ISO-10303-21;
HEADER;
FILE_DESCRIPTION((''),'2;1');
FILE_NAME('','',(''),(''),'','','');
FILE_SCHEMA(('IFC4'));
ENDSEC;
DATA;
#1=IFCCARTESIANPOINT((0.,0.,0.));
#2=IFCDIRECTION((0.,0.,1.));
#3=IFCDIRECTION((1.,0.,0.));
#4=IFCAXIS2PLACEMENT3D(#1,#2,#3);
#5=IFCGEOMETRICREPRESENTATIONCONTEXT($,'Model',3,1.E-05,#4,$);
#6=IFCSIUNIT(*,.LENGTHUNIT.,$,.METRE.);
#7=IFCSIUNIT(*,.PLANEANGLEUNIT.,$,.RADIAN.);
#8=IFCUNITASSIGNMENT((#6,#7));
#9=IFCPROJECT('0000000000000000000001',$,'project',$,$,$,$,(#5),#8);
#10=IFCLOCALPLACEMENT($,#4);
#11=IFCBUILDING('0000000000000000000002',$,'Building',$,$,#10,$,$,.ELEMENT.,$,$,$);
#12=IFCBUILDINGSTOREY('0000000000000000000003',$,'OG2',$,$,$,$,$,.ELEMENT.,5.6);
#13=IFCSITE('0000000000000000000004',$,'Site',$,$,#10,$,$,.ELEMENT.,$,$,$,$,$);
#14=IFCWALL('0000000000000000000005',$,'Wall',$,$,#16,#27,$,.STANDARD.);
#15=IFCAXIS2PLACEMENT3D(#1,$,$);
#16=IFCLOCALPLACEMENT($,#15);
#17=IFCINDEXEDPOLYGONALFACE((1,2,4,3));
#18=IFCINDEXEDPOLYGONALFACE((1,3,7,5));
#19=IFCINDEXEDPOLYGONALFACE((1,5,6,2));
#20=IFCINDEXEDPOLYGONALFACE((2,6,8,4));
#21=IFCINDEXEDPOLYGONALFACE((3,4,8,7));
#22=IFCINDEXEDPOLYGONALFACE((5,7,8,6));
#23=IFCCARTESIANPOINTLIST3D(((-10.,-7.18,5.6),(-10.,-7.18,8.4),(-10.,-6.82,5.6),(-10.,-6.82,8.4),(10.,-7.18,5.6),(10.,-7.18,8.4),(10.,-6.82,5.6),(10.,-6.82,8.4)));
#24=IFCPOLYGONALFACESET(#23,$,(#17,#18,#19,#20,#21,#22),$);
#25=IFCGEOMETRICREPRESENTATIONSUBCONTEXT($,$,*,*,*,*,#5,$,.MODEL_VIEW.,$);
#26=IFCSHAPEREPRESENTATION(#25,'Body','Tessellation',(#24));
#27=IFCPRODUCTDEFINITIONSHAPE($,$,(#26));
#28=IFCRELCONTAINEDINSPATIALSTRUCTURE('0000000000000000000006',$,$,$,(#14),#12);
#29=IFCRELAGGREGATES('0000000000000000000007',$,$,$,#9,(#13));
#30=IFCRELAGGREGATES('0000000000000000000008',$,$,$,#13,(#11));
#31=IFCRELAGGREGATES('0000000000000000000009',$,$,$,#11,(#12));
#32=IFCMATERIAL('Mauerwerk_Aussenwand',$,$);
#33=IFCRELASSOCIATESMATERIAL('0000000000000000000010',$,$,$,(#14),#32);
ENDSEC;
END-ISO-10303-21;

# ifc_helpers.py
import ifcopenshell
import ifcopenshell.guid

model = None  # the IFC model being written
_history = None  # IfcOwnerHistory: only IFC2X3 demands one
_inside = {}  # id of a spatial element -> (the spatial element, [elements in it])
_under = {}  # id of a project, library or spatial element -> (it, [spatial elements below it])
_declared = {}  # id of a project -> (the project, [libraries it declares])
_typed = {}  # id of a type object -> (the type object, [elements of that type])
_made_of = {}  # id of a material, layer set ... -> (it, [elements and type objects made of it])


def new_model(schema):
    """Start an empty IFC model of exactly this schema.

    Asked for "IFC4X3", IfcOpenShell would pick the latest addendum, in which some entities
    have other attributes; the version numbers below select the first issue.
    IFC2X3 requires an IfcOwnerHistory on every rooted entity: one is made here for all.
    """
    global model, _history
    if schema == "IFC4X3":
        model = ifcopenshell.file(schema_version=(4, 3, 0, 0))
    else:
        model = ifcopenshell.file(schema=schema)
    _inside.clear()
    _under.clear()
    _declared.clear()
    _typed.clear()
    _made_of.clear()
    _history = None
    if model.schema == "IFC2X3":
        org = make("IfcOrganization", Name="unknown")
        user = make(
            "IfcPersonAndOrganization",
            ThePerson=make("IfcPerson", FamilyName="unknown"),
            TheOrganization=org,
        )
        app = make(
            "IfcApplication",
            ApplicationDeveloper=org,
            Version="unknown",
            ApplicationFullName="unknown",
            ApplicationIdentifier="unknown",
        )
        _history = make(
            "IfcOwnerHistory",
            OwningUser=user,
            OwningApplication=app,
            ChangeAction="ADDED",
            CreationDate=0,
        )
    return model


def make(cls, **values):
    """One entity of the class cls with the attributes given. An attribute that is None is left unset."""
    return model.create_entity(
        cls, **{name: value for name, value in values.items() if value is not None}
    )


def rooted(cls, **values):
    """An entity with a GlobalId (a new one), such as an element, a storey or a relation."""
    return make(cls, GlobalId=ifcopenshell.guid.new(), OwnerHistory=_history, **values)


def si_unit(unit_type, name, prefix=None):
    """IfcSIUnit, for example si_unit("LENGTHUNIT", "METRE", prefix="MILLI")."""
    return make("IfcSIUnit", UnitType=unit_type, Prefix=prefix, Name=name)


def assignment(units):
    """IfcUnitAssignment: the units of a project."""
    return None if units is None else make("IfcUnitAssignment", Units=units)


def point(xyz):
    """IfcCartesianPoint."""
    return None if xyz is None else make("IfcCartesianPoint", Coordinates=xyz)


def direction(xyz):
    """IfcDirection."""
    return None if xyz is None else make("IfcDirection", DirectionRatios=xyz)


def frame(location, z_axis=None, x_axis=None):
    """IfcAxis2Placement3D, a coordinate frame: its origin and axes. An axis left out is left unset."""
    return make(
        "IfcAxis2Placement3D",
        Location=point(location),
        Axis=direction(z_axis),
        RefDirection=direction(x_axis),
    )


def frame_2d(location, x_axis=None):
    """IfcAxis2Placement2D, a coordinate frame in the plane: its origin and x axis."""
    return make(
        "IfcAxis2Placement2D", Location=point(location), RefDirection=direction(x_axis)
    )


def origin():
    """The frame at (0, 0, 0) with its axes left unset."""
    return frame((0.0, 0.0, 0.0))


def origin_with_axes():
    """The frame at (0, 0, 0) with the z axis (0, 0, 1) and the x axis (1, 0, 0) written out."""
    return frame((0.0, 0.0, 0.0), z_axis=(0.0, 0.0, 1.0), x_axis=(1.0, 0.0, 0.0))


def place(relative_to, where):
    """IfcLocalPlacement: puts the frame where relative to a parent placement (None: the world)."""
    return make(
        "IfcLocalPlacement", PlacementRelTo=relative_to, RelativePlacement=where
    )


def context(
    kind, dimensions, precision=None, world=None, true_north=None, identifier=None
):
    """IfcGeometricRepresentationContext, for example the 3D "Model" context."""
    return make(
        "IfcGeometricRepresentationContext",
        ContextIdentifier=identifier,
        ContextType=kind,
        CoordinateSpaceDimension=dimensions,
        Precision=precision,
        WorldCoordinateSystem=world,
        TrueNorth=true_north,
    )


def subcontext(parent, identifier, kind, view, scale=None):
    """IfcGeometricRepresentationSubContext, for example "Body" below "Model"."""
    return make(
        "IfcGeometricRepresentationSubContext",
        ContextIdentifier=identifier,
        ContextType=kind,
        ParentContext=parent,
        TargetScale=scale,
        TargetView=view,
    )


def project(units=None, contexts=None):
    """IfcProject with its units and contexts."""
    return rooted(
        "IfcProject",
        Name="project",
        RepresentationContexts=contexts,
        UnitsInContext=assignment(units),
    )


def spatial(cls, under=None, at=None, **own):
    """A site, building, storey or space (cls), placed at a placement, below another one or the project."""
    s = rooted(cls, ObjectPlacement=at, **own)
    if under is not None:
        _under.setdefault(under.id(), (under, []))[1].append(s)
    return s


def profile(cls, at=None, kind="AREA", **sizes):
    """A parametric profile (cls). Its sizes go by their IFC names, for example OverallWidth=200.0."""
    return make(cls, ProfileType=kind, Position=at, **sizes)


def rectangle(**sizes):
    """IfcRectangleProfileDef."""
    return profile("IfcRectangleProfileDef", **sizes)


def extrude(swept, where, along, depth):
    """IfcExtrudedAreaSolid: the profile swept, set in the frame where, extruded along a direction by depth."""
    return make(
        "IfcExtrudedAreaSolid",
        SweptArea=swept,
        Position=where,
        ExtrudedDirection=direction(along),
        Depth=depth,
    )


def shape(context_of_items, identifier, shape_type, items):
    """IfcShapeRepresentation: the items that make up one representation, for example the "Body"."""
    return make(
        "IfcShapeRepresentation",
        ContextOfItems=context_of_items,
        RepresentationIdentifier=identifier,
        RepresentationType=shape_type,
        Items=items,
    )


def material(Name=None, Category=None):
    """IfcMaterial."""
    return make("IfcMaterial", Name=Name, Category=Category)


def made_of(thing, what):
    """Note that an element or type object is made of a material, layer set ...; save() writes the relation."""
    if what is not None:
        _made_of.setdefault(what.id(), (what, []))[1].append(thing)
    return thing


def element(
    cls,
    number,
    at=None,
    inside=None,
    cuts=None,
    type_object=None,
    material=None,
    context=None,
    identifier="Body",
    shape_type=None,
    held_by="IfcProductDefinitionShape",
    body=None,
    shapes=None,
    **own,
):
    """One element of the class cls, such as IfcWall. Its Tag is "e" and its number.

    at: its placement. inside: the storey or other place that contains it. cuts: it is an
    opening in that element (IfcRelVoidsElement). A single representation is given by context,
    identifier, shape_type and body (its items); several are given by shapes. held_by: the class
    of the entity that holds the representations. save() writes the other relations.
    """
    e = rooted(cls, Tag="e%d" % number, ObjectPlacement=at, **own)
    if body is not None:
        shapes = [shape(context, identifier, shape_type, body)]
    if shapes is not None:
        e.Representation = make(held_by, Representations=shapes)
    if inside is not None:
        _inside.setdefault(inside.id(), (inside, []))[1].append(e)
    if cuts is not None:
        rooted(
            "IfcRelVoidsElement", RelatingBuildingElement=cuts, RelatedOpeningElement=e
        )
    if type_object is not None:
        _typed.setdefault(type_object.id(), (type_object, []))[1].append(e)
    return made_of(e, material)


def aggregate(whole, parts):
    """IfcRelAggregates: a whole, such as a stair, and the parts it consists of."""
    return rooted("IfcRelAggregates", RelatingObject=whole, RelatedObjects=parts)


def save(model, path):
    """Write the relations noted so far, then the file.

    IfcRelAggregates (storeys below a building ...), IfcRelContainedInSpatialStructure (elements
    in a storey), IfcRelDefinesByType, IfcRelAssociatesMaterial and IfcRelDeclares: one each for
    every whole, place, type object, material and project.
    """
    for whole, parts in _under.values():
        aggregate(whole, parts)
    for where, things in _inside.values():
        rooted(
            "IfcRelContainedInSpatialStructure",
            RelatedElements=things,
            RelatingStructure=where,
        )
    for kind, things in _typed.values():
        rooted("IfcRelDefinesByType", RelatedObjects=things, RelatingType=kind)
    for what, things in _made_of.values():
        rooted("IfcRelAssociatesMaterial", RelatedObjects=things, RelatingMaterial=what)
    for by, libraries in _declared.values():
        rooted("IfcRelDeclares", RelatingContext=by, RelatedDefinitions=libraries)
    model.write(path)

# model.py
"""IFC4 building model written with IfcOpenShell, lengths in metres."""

from ifc_helpers import new_model, si_unit, frame, frame_2d, origin, origin_with_axes, place, context, subcontext, project, spatial, rectangle, extrude, material, element, save


model = new_model("IFC4")

# Units and contexts
model_context = context("Model", 3, precision=1e-05, world=origin_with_axes())
sub_context = subcontext(model_context, None, None, "MODEL_VIEW")
ifc_project = project(units=[si_unit("LENGTHUNIT", "METRE"), si_unit("PLANEANGLEUNIT", "RADIAN")], contexts=[model_context])

# Site, building, storey
placement_1 = place(None, origin_with_axes())
site = spatial("IfcSite", under=ifc_project, at=placement_1, Name="Site", CompositionType="ELEMENT")
building = spatial("IfcBuilding", under=site, at=placement_1, Name="Building", CompositionType="ELEMENT")
storey = spatial("IfcBuildingStorey", under=building, Name="OG2", CompositionType="ELEMENT", Elevation=5.6)

# Wall
ifc_material = material(Name="Mauerwerk_Aussenwand")
placement_2 = place(None, origin_with_axes())
placement_3 = place(placement_2, frame((0.0, 0.0, 5.6)))
wall_placement = place(placement_3, frame((-10.0, -7.0, 0.0), x_axis=(1.0, 0.0, 0.0)))
element("IfcWall", 1, at=wall_placement, inside=storey, material=ifc_material, Name="Wall", PredefinedType="STANDARD", context=sub_context, shape_type="SweptSolid", body=[
    extrude(rectangle(XDim=20.0, YDim=0.36, at=frame_2d((10.0, 0.0))), origin(), (0.0, 0.0, 1.0), 2.8),
])

save(model, "model.ifc")
